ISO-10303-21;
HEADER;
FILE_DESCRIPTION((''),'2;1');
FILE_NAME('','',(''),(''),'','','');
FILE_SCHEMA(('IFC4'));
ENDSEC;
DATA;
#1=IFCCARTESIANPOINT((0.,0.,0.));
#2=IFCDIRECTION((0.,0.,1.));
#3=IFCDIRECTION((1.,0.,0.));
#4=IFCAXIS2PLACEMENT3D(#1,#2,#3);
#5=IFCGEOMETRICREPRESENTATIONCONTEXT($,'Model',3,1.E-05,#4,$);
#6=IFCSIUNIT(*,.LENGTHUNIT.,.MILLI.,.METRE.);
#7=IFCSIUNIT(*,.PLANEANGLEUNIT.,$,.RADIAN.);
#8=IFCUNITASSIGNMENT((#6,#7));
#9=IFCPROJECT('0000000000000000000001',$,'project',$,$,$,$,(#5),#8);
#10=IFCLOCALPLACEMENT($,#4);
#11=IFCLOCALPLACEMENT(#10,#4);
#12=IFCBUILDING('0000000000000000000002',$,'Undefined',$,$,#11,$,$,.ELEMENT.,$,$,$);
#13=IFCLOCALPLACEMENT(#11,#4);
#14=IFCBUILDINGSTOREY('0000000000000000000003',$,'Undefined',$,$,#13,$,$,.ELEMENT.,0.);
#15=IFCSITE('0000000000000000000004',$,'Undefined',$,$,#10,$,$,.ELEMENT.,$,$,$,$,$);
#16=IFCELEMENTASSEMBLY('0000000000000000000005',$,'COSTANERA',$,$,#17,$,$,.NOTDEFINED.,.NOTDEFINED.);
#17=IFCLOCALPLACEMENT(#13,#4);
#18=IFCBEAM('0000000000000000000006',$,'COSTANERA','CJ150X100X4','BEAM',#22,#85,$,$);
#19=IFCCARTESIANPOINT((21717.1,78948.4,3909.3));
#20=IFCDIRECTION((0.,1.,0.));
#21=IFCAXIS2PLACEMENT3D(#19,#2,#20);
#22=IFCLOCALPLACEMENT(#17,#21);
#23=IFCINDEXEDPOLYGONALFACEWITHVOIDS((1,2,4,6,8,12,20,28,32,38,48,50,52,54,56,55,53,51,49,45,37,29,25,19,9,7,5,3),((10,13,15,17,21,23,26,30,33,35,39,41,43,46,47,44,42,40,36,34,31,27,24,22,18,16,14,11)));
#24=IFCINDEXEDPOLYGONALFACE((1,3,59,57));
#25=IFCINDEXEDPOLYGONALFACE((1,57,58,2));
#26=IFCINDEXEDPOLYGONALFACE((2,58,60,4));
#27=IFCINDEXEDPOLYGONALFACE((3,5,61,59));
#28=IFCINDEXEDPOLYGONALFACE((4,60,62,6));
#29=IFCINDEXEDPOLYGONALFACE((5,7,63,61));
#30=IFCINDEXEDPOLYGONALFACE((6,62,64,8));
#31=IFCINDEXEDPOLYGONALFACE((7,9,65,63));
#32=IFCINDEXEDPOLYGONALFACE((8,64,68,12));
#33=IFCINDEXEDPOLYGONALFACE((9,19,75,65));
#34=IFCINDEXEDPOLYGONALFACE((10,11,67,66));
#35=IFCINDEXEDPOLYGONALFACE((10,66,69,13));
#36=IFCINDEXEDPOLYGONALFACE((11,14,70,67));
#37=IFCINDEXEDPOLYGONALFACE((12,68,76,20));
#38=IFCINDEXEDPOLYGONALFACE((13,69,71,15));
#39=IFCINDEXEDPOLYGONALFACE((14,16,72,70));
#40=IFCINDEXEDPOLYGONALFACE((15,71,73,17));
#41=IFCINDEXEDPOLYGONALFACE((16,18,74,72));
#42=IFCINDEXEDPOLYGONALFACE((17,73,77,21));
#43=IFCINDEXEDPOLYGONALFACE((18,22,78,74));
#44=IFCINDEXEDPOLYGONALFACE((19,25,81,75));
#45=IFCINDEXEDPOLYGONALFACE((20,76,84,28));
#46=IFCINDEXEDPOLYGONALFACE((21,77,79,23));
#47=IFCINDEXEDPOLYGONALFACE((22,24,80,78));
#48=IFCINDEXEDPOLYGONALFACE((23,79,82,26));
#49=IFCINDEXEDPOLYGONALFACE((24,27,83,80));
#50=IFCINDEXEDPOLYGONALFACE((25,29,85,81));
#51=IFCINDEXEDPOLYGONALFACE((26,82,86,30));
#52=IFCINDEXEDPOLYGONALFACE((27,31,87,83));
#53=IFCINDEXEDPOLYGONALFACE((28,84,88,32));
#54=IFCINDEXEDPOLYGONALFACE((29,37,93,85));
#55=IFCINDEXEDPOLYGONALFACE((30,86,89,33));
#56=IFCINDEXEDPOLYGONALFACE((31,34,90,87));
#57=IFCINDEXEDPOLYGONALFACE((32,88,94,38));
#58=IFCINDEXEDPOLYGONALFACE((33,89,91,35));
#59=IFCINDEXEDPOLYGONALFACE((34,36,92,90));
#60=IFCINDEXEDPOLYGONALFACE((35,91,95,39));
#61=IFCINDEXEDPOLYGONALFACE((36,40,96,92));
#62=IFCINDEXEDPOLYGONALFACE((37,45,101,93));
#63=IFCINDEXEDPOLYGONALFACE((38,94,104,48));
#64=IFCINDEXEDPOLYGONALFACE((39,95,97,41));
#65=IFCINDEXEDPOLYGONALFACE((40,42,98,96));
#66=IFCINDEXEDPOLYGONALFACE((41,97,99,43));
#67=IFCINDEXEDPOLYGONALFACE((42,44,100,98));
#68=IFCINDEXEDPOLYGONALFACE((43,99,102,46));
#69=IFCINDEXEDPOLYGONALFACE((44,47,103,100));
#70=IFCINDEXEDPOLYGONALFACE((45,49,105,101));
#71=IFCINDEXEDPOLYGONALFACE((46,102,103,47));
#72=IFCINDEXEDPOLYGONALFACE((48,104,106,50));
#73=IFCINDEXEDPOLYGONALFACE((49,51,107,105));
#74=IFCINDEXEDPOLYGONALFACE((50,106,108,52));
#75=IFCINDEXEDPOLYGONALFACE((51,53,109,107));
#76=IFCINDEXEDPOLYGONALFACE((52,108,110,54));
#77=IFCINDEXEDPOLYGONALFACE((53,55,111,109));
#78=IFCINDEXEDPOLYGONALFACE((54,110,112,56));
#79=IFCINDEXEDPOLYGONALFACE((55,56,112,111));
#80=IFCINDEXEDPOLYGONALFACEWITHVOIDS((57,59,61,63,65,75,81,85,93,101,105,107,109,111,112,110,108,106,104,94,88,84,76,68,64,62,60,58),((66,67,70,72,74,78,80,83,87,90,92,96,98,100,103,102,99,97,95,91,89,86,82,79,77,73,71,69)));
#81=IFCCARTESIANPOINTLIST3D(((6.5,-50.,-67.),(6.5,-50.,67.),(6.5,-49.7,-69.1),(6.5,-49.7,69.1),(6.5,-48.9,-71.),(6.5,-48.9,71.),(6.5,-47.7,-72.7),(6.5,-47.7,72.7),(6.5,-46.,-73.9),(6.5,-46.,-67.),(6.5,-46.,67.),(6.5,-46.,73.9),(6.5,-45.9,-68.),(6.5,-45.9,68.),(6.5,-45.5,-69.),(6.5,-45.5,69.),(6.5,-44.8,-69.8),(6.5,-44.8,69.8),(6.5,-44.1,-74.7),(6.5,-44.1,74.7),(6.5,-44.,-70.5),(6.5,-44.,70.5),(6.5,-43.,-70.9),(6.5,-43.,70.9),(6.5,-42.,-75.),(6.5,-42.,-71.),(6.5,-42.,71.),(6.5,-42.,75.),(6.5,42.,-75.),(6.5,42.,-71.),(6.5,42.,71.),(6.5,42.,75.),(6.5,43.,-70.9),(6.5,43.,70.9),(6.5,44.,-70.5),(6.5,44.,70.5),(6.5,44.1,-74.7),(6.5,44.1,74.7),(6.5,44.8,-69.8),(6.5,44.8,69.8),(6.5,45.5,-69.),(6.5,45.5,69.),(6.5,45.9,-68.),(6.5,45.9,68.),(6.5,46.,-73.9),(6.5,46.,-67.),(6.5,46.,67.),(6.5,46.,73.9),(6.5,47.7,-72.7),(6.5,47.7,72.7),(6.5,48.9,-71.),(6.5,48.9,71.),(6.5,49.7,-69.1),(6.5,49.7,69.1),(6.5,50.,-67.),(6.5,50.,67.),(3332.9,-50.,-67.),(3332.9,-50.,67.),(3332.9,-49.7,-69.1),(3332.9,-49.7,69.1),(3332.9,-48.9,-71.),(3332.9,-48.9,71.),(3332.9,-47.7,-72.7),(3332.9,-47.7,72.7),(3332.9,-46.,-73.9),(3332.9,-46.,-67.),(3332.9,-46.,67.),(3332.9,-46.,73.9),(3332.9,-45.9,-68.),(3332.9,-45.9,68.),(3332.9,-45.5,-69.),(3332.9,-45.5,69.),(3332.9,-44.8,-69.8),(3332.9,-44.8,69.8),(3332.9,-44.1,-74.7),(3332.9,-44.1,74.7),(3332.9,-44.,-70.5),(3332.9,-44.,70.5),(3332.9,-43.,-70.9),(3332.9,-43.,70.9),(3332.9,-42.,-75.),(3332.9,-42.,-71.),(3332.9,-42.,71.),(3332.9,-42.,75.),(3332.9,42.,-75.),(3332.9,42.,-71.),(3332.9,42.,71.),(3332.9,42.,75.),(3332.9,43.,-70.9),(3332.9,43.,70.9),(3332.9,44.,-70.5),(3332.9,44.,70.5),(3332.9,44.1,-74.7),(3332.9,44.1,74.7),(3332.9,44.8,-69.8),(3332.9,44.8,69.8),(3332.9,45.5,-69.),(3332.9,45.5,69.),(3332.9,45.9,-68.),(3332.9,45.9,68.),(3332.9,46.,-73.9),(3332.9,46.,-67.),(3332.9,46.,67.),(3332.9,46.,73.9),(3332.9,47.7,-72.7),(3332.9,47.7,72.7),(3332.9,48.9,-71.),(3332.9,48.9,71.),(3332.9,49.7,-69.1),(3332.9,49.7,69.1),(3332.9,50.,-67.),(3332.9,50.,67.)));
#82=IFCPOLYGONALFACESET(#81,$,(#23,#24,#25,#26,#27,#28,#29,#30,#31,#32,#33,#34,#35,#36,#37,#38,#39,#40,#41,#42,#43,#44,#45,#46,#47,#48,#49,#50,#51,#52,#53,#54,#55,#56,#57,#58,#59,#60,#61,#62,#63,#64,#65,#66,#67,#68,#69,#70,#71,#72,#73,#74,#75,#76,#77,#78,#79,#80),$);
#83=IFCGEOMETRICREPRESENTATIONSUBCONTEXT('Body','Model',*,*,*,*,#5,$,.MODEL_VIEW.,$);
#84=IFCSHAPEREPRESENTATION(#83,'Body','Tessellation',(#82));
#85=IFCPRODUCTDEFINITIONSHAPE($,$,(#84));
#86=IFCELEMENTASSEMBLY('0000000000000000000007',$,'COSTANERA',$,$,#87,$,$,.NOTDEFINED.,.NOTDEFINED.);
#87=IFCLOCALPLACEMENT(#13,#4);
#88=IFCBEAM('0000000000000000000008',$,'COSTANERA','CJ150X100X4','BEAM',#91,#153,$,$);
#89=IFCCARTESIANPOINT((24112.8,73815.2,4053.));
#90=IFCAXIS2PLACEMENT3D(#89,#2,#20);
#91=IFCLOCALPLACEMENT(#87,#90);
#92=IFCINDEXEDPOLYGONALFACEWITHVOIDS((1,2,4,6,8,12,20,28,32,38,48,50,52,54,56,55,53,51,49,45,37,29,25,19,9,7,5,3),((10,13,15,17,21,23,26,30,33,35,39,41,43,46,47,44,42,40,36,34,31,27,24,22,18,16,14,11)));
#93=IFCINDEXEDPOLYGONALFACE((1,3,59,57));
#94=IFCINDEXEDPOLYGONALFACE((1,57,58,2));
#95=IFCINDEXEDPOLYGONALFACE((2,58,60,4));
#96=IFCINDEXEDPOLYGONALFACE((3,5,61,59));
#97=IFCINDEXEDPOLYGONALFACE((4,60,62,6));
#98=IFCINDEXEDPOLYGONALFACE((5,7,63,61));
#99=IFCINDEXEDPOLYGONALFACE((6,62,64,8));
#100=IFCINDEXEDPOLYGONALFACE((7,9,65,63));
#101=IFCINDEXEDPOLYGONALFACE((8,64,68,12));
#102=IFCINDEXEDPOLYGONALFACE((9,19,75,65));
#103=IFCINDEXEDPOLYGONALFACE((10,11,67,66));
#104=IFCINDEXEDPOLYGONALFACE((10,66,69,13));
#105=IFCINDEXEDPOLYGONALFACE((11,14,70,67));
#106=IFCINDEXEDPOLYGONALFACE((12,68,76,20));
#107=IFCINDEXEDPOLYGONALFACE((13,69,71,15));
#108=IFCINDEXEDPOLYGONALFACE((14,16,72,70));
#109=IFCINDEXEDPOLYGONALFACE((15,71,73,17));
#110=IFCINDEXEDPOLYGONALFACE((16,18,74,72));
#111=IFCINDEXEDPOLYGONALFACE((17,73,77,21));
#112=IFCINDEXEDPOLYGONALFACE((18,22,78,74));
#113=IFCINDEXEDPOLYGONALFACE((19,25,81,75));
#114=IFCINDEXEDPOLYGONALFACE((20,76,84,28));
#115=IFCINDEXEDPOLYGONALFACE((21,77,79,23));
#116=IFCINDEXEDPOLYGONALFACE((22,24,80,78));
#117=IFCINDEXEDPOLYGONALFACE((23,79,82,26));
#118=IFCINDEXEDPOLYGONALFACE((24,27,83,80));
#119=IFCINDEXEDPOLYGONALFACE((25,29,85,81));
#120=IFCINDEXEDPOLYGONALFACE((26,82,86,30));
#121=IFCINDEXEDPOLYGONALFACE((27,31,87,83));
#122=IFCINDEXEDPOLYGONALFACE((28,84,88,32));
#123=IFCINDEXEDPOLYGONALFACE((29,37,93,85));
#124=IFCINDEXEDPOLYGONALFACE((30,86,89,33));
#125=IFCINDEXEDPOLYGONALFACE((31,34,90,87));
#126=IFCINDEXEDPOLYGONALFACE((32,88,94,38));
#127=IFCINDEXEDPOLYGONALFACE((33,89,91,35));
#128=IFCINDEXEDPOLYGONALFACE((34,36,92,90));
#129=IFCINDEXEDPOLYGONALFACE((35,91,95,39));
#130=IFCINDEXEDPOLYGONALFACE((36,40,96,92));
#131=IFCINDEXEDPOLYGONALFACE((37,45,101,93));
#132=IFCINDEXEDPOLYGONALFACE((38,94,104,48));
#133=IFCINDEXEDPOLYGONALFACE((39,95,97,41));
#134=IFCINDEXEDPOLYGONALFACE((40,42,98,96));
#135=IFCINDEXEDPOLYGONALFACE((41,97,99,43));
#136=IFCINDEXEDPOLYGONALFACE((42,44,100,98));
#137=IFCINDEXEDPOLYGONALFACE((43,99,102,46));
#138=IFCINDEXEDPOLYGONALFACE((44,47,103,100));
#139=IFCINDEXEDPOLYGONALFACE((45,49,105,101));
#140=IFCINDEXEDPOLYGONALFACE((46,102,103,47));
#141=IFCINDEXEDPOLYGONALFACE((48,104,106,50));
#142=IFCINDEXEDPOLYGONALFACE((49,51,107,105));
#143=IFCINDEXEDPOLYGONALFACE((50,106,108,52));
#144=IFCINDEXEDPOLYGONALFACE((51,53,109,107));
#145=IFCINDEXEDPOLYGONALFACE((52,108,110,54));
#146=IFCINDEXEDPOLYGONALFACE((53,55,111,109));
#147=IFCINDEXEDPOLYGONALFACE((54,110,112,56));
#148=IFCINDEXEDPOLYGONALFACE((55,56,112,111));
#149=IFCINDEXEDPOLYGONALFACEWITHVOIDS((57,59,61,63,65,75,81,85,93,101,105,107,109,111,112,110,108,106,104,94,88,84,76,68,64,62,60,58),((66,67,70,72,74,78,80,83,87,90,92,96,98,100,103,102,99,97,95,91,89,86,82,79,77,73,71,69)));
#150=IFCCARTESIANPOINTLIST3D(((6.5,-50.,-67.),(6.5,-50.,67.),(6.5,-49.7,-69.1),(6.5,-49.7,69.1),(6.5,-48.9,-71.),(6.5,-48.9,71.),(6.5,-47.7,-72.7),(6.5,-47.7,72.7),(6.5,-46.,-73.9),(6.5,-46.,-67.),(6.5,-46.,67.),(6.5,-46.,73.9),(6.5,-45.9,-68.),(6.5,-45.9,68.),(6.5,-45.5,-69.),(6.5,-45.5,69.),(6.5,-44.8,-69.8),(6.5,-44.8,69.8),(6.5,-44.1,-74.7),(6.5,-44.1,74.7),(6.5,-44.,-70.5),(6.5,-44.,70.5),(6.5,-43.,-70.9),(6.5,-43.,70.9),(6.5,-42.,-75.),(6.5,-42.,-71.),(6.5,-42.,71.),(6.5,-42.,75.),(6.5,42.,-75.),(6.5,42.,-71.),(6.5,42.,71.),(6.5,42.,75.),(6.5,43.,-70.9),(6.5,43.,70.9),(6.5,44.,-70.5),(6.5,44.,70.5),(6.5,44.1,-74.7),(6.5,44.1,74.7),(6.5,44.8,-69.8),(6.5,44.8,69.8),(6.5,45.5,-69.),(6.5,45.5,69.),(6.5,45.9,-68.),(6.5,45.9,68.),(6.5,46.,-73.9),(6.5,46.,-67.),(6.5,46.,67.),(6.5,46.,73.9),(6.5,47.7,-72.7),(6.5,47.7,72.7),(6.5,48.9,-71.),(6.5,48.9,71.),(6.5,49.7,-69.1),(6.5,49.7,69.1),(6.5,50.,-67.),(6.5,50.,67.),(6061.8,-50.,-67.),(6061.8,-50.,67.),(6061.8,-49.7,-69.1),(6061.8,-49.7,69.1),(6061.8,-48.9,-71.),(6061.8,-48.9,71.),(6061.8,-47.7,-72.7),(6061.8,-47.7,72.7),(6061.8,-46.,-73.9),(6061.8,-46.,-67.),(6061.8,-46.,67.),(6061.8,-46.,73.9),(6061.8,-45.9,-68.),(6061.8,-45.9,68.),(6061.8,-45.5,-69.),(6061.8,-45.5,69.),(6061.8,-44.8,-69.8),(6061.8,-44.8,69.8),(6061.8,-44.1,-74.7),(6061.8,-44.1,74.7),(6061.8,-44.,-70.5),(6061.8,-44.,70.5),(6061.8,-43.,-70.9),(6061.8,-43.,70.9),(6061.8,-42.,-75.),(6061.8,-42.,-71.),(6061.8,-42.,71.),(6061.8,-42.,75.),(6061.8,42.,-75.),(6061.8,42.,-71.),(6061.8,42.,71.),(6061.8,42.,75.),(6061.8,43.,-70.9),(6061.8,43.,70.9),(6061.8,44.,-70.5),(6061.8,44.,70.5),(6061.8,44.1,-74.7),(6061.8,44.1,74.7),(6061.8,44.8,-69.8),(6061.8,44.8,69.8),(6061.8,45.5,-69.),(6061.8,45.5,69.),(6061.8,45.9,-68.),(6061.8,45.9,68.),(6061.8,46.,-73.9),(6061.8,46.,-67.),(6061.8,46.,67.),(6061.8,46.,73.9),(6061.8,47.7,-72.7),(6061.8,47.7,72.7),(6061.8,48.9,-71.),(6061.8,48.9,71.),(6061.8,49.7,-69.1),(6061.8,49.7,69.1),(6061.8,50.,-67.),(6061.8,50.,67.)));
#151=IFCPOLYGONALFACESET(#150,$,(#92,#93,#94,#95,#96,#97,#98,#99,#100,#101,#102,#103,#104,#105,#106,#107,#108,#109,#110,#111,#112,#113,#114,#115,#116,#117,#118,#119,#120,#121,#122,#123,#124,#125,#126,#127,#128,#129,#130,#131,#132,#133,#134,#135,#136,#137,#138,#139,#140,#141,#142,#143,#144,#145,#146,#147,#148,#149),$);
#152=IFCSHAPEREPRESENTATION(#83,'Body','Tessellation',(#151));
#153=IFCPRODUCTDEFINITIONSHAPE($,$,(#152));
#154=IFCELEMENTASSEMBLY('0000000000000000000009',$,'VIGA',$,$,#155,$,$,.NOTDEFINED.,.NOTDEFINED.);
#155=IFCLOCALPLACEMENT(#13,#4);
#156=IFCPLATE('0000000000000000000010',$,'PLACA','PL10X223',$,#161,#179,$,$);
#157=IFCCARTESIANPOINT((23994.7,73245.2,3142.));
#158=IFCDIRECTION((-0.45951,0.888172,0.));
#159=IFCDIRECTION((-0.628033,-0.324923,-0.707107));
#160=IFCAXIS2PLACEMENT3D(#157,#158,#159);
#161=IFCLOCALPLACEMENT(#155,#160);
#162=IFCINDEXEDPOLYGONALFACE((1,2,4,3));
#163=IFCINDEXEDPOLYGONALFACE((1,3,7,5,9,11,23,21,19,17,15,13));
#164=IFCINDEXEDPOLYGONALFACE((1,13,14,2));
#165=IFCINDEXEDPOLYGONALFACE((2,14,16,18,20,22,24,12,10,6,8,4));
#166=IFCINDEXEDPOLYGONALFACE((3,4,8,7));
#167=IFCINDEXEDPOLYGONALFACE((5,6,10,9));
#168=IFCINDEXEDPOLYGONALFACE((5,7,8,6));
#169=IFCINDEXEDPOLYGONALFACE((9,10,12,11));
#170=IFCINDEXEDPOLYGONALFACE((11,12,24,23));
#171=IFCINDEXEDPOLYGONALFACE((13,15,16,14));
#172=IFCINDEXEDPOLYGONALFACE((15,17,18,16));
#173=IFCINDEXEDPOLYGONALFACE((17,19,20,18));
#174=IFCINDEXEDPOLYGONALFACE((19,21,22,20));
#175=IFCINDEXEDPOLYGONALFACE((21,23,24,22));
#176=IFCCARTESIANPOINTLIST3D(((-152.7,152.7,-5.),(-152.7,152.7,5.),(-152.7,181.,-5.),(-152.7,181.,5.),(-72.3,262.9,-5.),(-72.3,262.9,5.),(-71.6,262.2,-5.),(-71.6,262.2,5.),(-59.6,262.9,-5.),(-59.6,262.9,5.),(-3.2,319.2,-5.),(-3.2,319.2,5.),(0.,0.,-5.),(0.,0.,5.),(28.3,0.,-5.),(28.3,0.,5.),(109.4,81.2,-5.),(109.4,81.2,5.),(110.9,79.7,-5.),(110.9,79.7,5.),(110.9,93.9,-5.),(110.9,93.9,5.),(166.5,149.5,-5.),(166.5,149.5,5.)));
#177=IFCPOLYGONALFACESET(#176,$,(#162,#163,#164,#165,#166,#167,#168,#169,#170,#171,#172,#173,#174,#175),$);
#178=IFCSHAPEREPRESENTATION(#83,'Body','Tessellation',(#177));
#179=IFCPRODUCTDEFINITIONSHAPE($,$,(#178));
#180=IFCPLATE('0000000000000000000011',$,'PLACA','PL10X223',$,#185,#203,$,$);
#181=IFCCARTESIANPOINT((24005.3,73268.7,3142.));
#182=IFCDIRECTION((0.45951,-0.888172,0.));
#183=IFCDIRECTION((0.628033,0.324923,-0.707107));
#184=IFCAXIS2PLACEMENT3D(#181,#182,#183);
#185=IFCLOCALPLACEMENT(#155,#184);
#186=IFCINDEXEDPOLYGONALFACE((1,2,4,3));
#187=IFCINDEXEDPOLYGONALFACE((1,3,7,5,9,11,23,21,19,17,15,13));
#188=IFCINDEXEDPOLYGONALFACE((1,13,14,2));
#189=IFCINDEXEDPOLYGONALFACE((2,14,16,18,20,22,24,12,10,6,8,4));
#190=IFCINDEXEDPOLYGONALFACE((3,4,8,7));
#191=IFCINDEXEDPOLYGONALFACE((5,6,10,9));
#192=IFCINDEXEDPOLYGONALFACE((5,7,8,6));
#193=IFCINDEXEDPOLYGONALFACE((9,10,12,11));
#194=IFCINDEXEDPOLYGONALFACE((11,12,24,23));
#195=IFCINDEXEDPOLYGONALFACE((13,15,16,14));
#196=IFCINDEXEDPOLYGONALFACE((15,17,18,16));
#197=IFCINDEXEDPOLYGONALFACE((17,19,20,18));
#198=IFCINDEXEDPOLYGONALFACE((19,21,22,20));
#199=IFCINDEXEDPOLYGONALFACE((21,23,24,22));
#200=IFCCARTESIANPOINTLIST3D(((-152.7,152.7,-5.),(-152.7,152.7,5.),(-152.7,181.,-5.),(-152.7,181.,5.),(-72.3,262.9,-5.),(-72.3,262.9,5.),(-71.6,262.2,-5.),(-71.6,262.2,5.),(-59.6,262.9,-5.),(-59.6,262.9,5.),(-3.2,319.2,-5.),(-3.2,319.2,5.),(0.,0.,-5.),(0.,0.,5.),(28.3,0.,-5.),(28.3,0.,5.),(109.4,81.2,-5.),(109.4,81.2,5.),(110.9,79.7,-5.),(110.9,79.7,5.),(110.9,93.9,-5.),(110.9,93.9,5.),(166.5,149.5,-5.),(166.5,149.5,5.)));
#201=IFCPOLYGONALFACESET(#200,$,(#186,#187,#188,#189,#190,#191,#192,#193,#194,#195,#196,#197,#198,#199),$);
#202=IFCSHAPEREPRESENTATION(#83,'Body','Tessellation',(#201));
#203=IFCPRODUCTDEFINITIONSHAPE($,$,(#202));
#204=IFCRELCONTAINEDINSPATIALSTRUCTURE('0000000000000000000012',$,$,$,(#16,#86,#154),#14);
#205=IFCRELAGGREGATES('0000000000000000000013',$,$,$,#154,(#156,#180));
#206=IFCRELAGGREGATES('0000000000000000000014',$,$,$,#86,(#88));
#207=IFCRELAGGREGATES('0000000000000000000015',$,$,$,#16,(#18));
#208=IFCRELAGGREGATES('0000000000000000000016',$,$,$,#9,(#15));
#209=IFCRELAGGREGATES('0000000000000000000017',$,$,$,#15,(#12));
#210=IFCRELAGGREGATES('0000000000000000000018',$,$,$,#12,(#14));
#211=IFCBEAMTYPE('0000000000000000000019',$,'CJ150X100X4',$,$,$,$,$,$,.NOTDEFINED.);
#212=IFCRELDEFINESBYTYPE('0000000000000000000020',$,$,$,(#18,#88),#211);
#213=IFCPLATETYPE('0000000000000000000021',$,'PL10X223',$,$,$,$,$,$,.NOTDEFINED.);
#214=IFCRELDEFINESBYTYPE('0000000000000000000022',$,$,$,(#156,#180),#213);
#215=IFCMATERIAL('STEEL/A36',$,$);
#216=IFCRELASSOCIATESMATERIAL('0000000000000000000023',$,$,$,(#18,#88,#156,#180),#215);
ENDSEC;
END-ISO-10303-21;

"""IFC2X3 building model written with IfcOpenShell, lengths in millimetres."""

from ifc_helpers import new_model, si_unit, frame, origin_with_axes, origin_2d_with_axis, place, context, subcontext, project, spatial, polyline, hollow_rectangle, outline, extrude, clip, halfspace, material, type_object, element, aggregate, save


model = new_model("IFC2X3")

# Units and contexts
model_context = context("Model", 3, precision=1e-05, world=origin_with_axes())
body_context = subcontext(model_context, "Body", "Model", "MODEL_VIEW")
ifc_project = project(units=[si_unit("LENGTHUNIT", "METRE", prefix="MILLI"), si_unit("PLANEANGLEUNIT", "RADIAN")], contexts=[model_context])

# Site, building, storey
site_placement = place(None, origin_with_axes())
site = spatial("IfcSite", under=ifc_project, at=site_placement, Name="Undefined", CompositionType="ELEMENT")
building_placement = place(site_placement, origin_with_axes())
building = spatial("IfcBuilding", under=site, at=building_placement, Name="Undefined", CompositionType="ELEMENT")
storey_placement = place(building_placement, origin_with_axes())
storey = spatial("IfcBuildingStorey", under=building, at=storey_placement, Name="Undefined", CompositionType="ELEMENT", Elevation=0.0)

# Element assemblies, beams
ifc_material_1 = material(Name="STEEL/A36")
beam_type_1 = type_object("IfcBeamType", Name="CJ150X100X4", PredefinedType="NOTDEFINED")
assembly_1_placement = place(storey_placement, origin_with_axes())
assembly_1 = element("IfcElementAssembly", 1, at=assembly_1_placement, inside=storey, Name="COSTANERA", AssemblyPlace="NOTDEFINED", PredefinedType="NOTDEFINED")
beam_1_placement = place(assembly_1_placement, frame((21717.1, 78948.4, 3909.3), z_axis=(0.0, 0.0, 1.0), x_axis=(0.0, 1.0, 0.0)))
beam_1 = element("IfcBeam", 2, at=beam_1_placement, type_object=beam_type_1, material=ifc_material_1, Name="COSTANERA", Description="CJ150X100X4", ObjectType="BEAM", context=body_context, shape_type="Clipping", body=[
    clip(extrude(hollow_rectangle(XDim=100.0, YDim=150.0, WallThickness=4.0, InnerFilletRadius=4.0, OuterFilletRadius=8.0, at=origin_2d_with_axis()), frame((3332.9, 0.0, 0.0), z_axis=(-1.0, 0.0, 0.0), x_axis=(0.0, -1.0, 0.0)), (0.0, 0.0, 1.0), 3332.9), halfspace(frame((6.5, 0.0, -1000.0), z_axis=(1.0, 0.0, 0.0), x_axis=(0.0, -1.0, 0.0)), True)),
])
assembly_2_placement = place(storey_placement, origin_with_axes())
assembly_2 = element("IfcElementAssembly", 3, at=assembly_2_placement, inside=storey, Name="COSTANERA", AssemblyPlace="NOTDEFINED", PredefinedType="NOTDEFINED")
beam_2_placement = place(assembly_2_placement, frame((24112.8, 73815.2, 4053.0), z_axis=(0.0, 0.0, 1.0), x_axis=(0.0, 1.0, 0.0)))
beam_2 = element("IfcBeam", 4, at=beam_2_placement, type_object=beam_type_1, material=ifc_material_1, Name="COSTANERA", Description="CJ150X100X4", ObjectType="BEAM", context=body_context, shape_type="Clipping", body=[
    clip(extrude(hollow_rectangle(XDim=100.0, YDim=150.0, WallThickness=4.0, InnerFilletRadius=4.0, OuterFilletRadius=8.0, at=origin_2d_with_axis()), frame((6061.8, 0.0, 0.0), z_axis=(-1.0, 0.0, 0.0), x_axis=(0.0, -1.0, 0.0)), (0.0, 0.0, 1.0), 6061.8), halfspace(frame((6.5, 0.0, -1000.0), z_axis=(1.0, 0.0, 0.0), x_axis=(0.0, -1.0, 0.0)), True)),
])

# Element assembly, plates
assembly_3_placement = place(storey_placement, origin_with_axes())
assembly_3 = element("IfcElementAssembly", 5, at=assembly_3_placement, inside=storey, Name="VIGA", AssemblyPlace="NOTDEFINED", PredefinedType="NOTDEFINED")
plate_type_1 = type_object("IfcPlateType", Name="PL10X223", PredefinedType="NOTDEFINED")
plate_1_placement = place(assembly_3_placement, frame((23994.7, 73245.2, 3142.0), z_axis=(-0.45951, 0.888172, 0.0), x_axis=(-0.628033, -0.324923, -0.707107)))
plate_1 = element("IfcPlate", 6, at=plate_1_placement, type_object=plate_type_1, material=ifc_material_1, Name="PLACA", Description="PL10X223", context=body_context, shape_type="SweptSolid", body=[
    extrude(outline(polyline([(0.0, 0.0), (28.3, 0.0), (109.4, 81.2), (110.9, 79.7), (110.9, 93.9), (166.5, 149.5), (-3.2, 319.2), (-59.6, 262.9), (-72.3, 262.9), (-71.6, 262.2), (-152.7, 181.0), (-152.7, 152.7), (0.0, 0.0)])), frame((0.0, 0.0, -5.0), z_axis=(0.0, 0.0, 1.0), x_axis=(1.0, 0.0, 0.0)), (0.0, 0.0, 1.0), 10.0),
])
plate_2_placement = place(assembly_3_placement, frame((24005.3, 73268.7, 3142.0), z_axis=(0.45951, -0.888172, 0.0), x_axis=(0.628033, 0.324923, -0.707107)))
plate_2 = element("IfcPlate", 7, at=plate_2_placement, type_object=plate_type_1, material=ifc_material_1, Name="PLACA", Description="PL10X223", context=body_context, shape_type="SweptSolid", body=[
    extrude(outline(polyline([(0.0, 0.0), (28.3, 0.0), (109.4, 81.2), (110.9, 79.7), (110.9, 93.9), (166.5, 149.5), (-3.2, 319.2), (-59.6, 262.9), (-72.3, 262.9), (-71.6, 262.2), (-152.7, 181.0), (-152.7, 152.7), (0.0, 0.0)])), frame((0.0, 0.0, -5.0), z_axis=(0.0, 0.0, 1.0), x_axis=(1.0, 0.0, 0.0)), (0.0, 0.0, 1.0), 10.0),
])
aggregate(assembly_3, [plate_1, plate_2])

aggregate(assembly_2, [beam_2])

aggregate(assembly_1, [beam_1])

save(model, "model.ifc")
